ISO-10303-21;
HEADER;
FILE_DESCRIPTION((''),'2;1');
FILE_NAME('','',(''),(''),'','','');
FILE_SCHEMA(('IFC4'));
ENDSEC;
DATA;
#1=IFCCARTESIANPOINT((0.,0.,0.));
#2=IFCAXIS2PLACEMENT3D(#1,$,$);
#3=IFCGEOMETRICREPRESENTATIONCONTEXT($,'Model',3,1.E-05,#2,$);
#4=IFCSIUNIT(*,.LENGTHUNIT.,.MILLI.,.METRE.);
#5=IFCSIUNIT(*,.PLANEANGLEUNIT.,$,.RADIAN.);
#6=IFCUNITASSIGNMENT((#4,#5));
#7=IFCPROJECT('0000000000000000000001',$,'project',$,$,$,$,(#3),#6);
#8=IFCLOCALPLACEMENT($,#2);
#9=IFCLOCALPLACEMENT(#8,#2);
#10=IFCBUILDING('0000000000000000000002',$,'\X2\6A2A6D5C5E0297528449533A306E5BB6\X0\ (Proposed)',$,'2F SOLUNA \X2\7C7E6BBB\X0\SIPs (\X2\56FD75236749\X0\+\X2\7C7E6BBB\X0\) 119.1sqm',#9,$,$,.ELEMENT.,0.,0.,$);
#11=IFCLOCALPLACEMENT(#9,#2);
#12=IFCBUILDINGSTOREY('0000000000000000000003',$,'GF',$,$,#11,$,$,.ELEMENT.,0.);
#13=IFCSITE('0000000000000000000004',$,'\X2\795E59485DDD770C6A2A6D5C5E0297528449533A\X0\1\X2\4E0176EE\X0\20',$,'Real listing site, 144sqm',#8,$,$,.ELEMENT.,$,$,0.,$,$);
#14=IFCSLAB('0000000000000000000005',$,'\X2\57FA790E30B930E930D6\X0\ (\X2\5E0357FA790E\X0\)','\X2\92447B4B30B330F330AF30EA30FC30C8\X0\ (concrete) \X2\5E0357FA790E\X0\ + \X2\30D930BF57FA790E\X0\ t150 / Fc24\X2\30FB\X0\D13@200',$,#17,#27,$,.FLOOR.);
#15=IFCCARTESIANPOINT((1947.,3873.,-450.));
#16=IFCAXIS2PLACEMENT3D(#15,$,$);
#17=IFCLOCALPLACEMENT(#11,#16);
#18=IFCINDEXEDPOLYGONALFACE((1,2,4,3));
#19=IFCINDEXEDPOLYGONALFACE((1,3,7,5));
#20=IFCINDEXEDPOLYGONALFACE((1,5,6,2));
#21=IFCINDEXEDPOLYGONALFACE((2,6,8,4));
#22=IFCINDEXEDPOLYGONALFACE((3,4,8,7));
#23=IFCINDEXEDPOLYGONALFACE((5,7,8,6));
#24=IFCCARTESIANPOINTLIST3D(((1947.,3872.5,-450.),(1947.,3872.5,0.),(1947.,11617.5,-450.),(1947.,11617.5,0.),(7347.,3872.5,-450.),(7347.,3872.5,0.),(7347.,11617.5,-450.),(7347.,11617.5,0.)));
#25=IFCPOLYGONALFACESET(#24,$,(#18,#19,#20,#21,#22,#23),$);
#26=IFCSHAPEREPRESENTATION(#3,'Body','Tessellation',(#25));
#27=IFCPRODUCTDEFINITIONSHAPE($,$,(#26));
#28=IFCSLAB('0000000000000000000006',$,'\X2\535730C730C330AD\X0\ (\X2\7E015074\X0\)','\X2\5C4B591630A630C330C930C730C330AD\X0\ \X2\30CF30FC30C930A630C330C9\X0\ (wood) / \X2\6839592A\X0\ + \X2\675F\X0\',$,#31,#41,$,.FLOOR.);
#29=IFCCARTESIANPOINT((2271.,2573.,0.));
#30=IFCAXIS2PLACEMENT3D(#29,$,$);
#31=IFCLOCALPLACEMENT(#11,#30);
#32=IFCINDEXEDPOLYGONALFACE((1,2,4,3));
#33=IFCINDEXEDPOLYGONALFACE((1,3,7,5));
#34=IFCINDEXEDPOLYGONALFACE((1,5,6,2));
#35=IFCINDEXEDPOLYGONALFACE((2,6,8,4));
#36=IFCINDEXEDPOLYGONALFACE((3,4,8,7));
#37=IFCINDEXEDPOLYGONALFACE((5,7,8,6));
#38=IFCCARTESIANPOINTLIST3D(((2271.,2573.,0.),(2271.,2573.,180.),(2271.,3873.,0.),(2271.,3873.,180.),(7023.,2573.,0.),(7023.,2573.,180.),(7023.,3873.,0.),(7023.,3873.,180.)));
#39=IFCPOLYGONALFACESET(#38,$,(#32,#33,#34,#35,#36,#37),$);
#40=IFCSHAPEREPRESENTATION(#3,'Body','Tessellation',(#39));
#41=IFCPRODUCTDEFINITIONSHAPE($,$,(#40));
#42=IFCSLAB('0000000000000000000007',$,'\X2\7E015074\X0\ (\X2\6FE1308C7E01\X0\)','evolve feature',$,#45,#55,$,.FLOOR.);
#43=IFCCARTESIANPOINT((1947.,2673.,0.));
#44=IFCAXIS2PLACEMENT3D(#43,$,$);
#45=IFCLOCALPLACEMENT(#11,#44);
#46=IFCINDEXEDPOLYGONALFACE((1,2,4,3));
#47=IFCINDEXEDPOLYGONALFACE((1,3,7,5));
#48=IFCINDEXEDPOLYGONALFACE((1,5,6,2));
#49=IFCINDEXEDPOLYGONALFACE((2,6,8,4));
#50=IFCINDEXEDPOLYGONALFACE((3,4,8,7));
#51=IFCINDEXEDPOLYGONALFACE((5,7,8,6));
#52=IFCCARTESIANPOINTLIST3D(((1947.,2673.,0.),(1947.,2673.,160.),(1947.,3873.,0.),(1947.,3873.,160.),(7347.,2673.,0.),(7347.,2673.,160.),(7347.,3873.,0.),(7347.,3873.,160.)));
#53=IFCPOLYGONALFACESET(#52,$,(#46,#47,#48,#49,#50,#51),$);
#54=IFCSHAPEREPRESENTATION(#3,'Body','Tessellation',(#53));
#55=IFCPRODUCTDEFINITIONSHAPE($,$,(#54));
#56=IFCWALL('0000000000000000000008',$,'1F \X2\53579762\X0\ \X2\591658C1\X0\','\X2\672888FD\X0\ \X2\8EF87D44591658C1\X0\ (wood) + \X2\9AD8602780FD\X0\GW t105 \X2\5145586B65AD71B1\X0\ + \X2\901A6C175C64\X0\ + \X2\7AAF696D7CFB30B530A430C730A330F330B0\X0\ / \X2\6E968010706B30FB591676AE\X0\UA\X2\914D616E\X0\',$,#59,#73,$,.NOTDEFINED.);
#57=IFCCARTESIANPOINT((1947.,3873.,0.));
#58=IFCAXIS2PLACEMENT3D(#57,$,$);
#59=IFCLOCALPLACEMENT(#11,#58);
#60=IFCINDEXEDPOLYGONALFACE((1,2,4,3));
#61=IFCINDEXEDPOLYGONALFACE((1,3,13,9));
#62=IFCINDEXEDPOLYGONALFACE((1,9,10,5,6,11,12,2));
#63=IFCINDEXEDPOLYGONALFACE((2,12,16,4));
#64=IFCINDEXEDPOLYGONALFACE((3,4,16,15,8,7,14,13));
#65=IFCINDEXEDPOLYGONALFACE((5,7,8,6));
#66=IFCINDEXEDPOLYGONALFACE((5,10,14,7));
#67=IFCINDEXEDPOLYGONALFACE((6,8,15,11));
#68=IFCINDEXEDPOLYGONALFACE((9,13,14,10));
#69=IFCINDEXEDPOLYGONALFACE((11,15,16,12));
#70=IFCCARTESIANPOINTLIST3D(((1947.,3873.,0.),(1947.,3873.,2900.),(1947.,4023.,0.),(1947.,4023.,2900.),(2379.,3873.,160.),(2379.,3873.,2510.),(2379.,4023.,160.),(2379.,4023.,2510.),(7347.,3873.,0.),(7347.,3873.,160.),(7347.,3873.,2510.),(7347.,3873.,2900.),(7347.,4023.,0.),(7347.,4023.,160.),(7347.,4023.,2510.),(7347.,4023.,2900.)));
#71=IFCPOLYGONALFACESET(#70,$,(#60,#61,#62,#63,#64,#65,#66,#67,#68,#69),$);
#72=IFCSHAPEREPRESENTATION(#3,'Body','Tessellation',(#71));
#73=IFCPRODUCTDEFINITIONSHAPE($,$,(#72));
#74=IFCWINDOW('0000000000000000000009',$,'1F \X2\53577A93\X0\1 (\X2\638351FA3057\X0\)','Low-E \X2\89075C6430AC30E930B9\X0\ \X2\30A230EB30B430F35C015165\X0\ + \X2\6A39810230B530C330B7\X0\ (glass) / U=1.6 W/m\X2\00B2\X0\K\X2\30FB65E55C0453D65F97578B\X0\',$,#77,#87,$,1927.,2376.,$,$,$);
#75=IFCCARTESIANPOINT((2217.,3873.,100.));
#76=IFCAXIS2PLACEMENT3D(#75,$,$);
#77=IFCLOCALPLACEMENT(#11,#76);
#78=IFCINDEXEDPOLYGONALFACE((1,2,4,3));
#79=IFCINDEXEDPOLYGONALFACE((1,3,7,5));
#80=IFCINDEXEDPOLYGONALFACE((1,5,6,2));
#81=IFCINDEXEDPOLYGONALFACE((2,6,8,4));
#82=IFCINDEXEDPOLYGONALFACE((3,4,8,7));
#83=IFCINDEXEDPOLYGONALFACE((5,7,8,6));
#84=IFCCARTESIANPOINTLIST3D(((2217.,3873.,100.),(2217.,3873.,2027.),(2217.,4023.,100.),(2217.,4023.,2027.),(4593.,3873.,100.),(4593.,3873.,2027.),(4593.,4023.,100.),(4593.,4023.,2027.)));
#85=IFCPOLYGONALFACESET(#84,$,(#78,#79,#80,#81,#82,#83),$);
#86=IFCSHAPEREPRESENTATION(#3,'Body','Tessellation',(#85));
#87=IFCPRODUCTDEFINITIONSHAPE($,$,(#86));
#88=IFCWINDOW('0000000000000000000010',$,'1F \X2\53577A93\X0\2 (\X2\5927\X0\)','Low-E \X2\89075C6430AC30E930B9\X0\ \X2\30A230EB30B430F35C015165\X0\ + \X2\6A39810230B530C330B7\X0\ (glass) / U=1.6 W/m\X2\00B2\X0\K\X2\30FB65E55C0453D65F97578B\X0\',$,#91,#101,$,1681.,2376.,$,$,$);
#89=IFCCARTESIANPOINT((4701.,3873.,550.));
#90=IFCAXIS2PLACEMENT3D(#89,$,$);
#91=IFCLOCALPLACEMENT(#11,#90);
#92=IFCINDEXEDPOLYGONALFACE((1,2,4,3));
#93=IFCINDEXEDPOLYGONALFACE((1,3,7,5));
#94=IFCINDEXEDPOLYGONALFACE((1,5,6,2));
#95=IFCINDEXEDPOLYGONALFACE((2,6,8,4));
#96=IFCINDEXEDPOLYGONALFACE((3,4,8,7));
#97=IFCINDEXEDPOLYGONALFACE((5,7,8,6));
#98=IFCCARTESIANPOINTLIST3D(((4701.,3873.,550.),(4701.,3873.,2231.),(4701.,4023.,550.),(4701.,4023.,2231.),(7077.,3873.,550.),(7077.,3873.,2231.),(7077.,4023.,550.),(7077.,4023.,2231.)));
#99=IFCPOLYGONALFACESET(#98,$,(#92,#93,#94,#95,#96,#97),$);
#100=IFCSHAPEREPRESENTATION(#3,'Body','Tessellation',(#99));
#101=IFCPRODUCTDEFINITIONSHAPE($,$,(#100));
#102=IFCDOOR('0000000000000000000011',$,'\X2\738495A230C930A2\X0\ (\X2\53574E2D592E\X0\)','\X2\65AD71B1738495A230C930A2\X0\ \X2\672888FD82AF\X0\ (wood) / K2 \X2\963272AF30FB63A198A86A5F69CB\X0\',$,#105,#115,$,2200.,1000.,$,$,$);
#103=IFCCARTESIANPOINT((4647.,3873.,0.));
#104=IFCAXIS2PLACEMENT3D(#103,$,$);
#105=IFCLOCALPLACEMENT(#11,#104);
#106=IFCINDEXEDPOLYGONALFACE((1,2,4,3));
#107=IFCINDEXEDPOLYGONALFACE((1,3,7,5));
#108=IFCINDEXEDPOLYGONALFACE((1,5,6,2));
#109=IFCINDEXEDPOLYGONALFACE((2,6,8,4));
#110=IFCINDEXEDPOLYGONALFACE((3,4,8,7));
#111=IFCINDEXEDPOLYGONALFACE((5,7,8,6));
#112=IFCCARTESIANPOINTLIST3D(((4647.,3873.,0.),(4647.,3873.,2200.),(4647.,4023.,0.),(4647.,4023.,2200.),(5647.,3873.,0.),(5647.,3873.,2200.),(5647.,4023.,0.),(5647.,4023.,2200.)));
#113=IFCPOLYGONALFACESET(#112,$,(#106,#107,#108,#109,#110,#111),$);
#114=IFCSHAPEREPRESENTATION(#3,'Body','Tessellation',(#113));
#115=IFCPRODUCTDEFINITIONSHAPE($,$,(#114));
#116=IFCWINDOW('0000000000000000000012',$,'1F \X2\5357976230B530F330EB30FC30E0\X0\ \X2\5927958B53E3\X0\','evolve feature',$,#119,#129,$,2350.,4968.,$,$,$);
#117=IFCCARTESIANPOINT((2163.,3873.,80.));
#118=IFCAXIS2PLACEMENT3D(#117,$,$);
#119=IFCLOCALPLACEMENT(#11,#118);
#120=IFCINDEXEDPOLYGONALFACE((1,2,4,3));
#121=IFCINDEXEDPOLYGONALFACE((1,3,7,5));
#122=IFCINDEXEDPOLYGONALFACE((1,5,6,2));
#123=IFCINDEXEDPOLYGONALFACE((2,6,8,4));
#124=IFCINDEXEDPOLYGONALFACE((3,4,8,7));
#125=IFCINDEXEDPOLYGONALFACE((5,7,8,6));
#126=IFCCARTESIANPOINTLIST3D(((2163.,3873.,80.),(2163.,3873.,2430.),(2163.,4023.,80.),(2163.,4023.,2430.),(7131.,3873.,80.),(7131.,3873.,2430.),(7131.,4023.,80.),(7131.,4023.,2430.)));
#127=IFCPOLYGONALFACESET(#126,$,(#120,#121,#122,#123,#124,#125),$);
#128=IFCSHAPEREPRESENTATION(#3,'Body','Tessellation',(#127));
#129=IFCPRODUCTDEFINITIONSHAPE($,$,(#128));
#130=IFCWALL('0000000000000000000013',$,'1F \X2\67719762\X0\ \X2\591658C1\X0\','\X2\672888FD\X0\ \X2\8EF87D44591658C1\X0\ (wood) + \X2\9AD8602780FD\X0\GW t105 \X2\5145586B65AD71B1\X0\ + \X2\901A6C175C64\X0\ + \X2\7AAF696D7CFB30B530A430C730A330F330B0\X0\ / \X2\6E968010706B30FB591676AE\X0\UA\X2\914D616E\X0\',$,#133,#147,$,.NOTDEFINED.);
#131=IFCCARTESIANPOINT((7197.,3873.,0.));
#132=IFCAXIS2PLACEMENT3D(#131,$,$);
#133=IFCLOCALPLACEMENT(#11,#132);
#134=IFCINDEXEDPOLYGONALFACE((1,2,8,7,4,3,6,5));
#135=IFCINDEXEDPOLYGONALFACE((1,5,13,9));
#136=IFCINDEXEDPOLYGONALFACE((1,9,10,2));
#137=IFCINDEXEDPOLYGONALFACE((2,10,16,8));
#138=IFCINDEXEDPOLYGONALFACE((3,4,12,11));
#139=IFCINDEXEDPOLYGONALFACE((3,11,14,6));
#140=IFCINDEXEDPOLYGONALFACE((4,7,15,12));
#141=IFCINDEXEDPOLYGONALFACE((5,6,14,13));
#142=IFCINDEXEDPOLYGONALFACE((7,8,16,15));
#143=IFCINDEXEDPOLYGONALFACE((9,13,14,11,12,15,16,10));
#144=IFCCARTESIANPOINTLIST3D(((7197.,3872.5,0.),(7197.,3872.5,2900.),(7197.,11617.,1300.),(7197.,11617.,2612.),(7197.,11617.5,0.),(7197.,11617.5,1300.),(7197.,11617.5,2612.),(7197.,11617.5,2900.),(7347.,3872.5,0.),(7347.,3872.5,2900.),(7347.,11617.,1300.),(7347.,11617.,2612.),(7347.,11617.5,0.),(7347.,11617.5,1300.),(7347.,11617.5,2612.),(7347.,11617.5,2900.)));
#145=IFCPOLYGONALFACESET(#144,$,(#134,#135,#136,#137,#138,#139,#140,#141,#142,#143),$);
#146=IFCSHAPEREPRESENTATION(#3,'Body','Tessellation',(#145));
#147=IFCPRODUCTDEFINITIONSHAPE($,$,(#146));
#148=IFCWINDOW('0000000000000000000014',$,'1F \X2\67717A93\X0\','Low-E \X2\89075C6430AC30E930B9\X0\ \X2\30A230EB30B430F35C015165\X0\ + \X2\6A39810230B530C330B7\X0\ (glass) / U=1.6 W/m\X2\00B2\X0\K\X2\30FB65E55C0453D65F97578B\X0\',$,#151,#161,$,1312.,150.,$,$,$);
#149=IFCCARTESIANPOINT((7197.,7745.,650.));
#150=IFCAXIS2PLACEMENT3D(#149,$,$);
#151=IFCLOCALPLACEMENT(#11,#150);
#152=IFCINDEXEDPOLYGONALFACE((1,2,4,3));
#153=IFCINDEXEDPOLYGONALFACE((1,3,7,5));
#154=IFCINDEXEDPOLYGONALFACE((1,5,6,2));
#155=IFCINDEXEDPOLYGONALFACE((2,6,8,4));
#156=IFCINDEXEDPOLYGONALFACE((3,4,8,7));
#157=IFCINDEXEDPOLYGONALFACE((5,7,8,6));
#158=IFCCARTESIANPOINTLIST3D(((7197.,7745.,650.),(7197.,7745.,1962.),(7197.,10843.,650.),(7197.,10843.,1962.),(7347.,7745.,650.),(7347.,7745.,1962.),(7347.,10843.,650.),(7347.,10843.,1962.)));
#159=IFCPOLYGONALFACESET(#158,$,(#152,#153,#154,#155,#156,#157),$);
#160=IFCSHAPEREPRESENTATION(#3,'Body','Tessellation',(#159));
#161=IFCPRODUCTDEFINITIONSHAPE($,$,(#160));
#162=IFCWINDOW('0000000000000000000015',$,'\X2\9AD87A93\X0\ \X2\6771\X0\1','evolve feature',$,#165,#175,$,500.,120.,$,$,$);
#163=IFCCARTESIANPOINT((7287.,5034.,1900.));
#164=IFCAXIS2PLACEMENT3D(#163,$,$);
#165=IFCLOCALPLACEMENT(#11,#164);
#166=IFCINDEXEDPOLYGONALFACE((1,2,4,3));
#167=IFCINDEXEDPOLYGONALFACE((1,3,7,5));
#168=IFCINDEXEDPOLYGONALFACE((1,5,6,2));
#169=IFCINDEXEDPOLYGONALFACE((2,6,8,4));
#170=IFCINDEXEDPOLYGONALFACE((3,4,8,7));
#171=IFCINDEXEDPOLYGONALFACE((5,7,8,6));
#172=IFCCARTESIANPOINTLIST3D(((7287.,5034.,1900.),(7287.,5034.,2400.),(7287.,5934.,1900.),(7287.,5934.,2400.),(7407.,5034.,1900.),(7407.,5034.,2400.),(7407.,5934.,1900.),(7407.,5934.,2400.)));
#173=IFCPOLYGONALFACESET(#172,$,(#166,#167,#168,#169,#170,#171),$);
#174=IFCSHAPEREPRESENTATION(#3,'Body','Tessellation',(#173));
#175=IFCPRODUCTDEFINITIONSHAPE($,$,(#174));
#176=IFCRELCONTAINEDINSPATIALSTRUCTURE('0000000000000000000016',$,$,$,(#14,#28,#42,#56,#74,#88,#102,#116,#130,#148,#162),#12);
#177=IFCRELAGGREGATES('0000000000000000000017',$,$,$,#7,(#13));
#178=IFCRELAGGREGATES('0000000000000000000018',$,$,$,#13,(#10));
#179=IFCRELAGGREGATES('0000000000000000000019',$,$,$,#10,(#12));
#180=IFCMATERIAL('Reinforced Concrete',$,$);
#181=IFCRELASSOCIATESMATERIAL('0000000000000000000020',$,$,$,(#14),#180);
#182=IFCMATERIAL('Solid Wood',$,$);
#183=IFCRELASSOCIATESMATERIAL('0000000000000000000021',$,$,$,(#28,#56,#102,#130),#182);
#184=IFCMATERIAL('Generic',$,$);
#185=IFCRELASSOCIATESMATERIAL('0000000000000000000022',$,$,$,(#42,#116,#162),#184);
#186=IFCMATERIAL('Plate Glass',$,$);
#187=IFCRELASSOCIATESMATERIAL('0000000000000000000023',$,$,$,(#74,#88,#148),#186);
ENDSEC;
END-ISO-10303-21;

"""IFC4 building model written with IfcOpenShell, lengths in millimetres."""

from ifc_helpers import new_model, si_unit, frame, frame_2d, origin, place, context, project, spatial, rectangle, extrude, material, element, fill, save


model = new_model("IFC4")

# Units and contexts
model_context = context("Model", 3, precision=1e-05, world=origin())
ifc_project = project(units=[si_unit("LENGTHUNIT", "METRE", prefix="MILLI"), si_unit("PLANEANGLEUNIT", "RADIAN")], contexts=[model_context])

# Site, building, storey
site_placement = place(None, origin())
site = spatial("IfcSite", under=ifc_project, at=site_placement, Name="神奈川県横浜市青葉区1丁目20", ObjectType="Real listing site, 144sqm", CompositionType="ELEMENT", RefElevation=0.0)
building_placement = place(site_placement, origin())
building = spatial("IfcBuilding", under=site, at=building_placement, Name="横浜市青葉区の家 (Proposed)", ObjectType="2F SOLUNA 籾殻SIPs (国産杉+籾殻) 119.1sqm", CompositionType="ELEMENT", ElevationOfRefHeight=0.0, ElevationOfTerrain=0.0)
storey_placement = place(building_placement, origin())
storey = spatial("IfcBuildingStorey", under=building, at=storey_placement, Name="GF", CompositionType="ELEMENT", Elevation=0.0)

# Slabs
ifc_material_1 = material(Name="Reinforced Concrete")
slab_1_placement = place(storey_placement, frame((1947.0, 3873.0, -450.0)))
element("IfcSlab", 1, at=slab_1_placement, inside=storey, material=ifc_material_1, Name="基礎スラブ (布基礎)", Description="鉄筋コンクリート (concrete) 布基礎 + ベタ基礎 t150 / Fc24・D13@200", PredefinedType="FLOOR", context=model_context, shape_type="SweptSolid", body=[
    extrude(rectangle(XDim=5400.0, YDim=7745.0, at=frame_2d((2700.0, 3872.0))), frame((1947.0, 3873.0, -450.0)), (0.0, 0.0, 1.0), 450.0),
])
ifc_material_2 = material(Name="Solid Wood")
slab_2_placement = place(storey_placement, frame((2271.0, 2573.0, 0.0)))
element("IfcSlab", 2, at=slab_2_placement, inside=storey, material=ifc_material_2, Name="南デッキ (縁側)", Description="屋外ウッドデッキ ハードウッド (wood) / 根太 + 束", PredefinedType="FLOOR", context=model_context, shape_type="SweptSolid", body=[
    extrude(rectangle(XDim=4752.0, YDim=1300.0, at=frame_2d((2376.0, 650.0))), frame((2271.0, 2573.0, 0.0)), (0.0, 0.0, 1.0), 180.0),
])
ifc_material_3 = material(Name="Generic")
slab_3_placement = place(storey_placement, frame((1947.0, 2673.0, 0.0)))
element("IfcSlab", 3, at=slab_3_placement, inside=storey, material=ifc_material_3, Name="縁側 (濡れ縁)", Description="evolve feature", PredefinedType="FLOOR", context=model_context, shape_type="SweptSolid", body=[
    extrude(rectangle(XDim=5400.0, YDim=1200.0, at=frame_2d((2700.0, 600.0))), frame((1947.0, 2673.0, 0.0)), (0.0, 0.0, 1.0), 160.0),
])

# Wall, openings, windows, door
wall_1_placement = place(storey_placement, frame((1947.0, 3873.0, 0.0)))
wall_1 = element("IfcWall", 4, at=wall_1_placement, inside=storey, material=ifc_material_2, Name="1F 南面 外壁", Description="木製 軸組外壁 (wood) + 高性能GW t105 充填断熱 + 通気層 + 窯業系サイディング / 準耐火・外皮UA配慮", PredefinedType="NOTDEFINED", context=model_context, shape_type="SweptSolid", body=[
    extrude(rectangle(XDim=5400.0, YDim=150.0, at=frame_2d((2700.0, 75.0))), frame((1947.0, 3873.0, 0.0)), (0.0, 0.0, 1.0), 2900.0),
])
opening_1_placement = place(storey_placement, frame((2217.0, 3873.0, 100.0)))
opening_1 = element("IfcOpeningElement", 5, at=opening_1_placement, cuts=wall_1, PredefinedType="NOTDEFINED", context=model_context, shape_type="SweptSolid", body=[
    extrude(rectangle(XDim=2376.0, YDim=150.0, at=frame_2d((1188.0, 75.0))), frame((2217.0, 3873.0, 100.0)), (0.0, 0.0, 1.0), 1927.0),
])
opening_2_placement = place(storey_placement, frame((4701.0, 3873.0, 550.0)))
opening_2 = element("IfcOpeningElement", 6, at=opening_2_placement, cuts=wall_1, PredefinedType="NOTDEFINED", context=model_context, shape_type="SweptSolid", body=[
    extrude(rectangle(XDim=2376.0, YDim=150.0, at=frame_2d((1188.0, 75.0))), frame((4701.0, 3873.0, 550.0)), (0.0, 0.0, 1.0), 1681.0),
])
opening_3_placement = place(storey_placement, frame((4647.0, 3873.0, 0.0)))
opening_3 = element("IfcOpeningElement", 7, at=opening_3_placement, cuts=wall_1, PredefinedType="NOTDEFINED", context=model_context, shape_type="SweptSolid", body=[
    extrude(rectangle(XDim=1000.0, YDim=150.0, at=frame_2d((500.0, 75.0))), frame((4647.0, 3873.0, 0.0)), (0.0, 0.0, 1.0), 2200.0),
])
opening_4_placement = place(storey_placement, frame((2163.0, 3873.0, 80.0)))
opening_4 = element("IfcOpeningElement", 8, at=opening_4_placement, cuts=wall_1, PredefinedType="NOTDEFINED", context=model_context, shape_type="SweptSolid", body=[
    extrude(rectangle(XDim=4968.0, YDim=150.0, at=frame_2d((2484.0, 75.0))), frame((2163.0, 3873.0, 80.0)), (0.0, 0.0, 1.0), 2350.0),
])
ifc_material_4 = material(Name="Plate Glass")
window_1_placement = place(storey_placement, frame((2217.0, 3873.0, 100.0)))
window_1 = element("IfcWindow", 9, at=window_1_placement, inside=storey, material=ifc_material_4, Name="1F 南窓1 (掃出し)", Description="Low-E 複層ガラス アルゴン封入 + 樹脂サッシ (glass) / U=1.6 W/m²K・日射取得型", OverallHeight=1927.0, OverallWidth=2376.0, context=model_context, shape_type="SweptSolid", body=[
    extrude(rectangle(XDim=2376.0, YDim=150.0, at=frame_2d((1188.0, 75.0))), frame((2217.0, 3873.0, 100.0)), (0.0, 0.0, 1.0), 1927.0),
])
fill(opening_1, window_1)
window_2_placement = place(storey_placement, frame((4701.0, 3873.0, 550.0)))
window_2 = element("IfcWindow", 10, at=window_2_placement, inside=storey, material=ifc_material_4, Name="1F 南窓2 (大)", Description="Low-E 複層ガラス アルゴン封入 + 樹脂サッシ (glass) / U=1.6 W/m²K・日射取得型", OverallHeight=1681.0, OverallWidth=2376.0, context=model_context, shape_type="SweptSolid", body=[
    extrude(rectangle(XDim=2376.0, YDim=150.0, at=frame_2d((1188.0, 75.0))), frame((4701.0, 3873.0, 550.0)), (0.0, 0.0, 1.0), 1681.0),
])
fill(opening_2, window_2)
door_placement = place(storey_placement, frame((4647.0, 3873.0, 0.0)))
door = element("IfcDoor", 11, at=door_placement, inside=storey, material=ifc_material_2, Name="玄関ドア (南中央)", Description="断熱玄関ドア 木製芯 (wood) / K2 防犯・採風機構", OverallHeight=2200.0, OverallWidth=1000.0, context=model_context, shape_type="SweptSolid", body=[
    extrude(rectangle(XDim=1000.0, YDim=150.0, at=frame_2d((500.0, 75.0))), frame((4647.0, 3873.0, 0.0)), (0.0, 0.0, 1.0), 2200.0),
])
fill(opening_3, door)
window_3_placement = place(storey_placement, frame((2163.0, 3873.0, 80.0)))
window_3 = element("IfcWindow", 12, at=window_3_placement, inside=storey, material=ifc_material_3, Name="1F 南面サンルーム 大開口", Description="evolve feature", OverallHeight=2350.0, OverallWidth=4968.0, context=model_context, shape_type="SweptSolid", body=[
    extrude(rectangle(XDim=4968.0, YDim=150.0, at=frame_2d((2484.0, 75.0))), frame((2163.0, 3873.0, 80.0)), (0.0, 0.0, 1.0), 2350.0),
])
fill(opening_4, window_3)

# Wall, openings, windows
wall_2_placement = place(storey_placement, frame((7197.0, 3873.0, 0.0)))
wall_2 = element("IfcWall", 13, at=wall_2_placement, inside=storey, material=ifc_material_2, Name="1F 東面 外壁", Description="木製 軸組外壁 (wood) + 高性能GW t105 充填断熱 + 通気層 + 窯業系サイディング / 準耐火・外皮UA配慮", PredefinedType="NOTDEFINED", context=model_context, shape_type="SweptSolid", body=[
    extrude(rectangle(XDim=150.0, YDim=7745.0, at=frame_2d((75.0, 3872.0))), frame((7197.0, 3873.0, 0.0)), (0.0, 0.0, 1.0), 2900.0),
])
opening_5_placement = place(storey_placement, frame((7197.0, 7745.0, 650.0)))
opening_5 = element("IfcOpeningElement", 14, at=opening_5_placement, cuts=wall_2, PredefinedType="NOTDEFINED", context=model_context, shape_type="SweptSolid", body=[
    extrude(rectangle(XDim=150.0, YDim=3098.0, at=frame_2d((75.0, 1549.0))), frame((7197.0, 7745.0, 650.0)), (0.0, 0.0, 1.0), 1312.0),
])
opening_6_placement = place(storey_placement, frame((7287.0, 5034.0, 1900.0)))
opening_6 = element("IfcOpeningElement", 15, at=opening_6_placement, cuts=wall_2, PredefinedType="NOTDEFINED", context=model_context, shape_type="SweptSolid", body=[
    extrude(rectangle(XDim=120.0, YDim=900.0, at=frame_2d((60.0, 450.0))), frame((7287.0, 5034.0, 1900.0)), (0.0, 0.0, 1.0), 500.0),
])
window_4_placement = place(storey_placement, frame((7197.0, 7745.0, 650.0)))
window_4 = element("IfcWindow", 16, at=window_4_placement, inside=storey, material=ifc_material_4, Name="1F 東窓", Description="Low-E 複層ガラス アルゴン封入 + 樹脂サッシ (glass) / U=1.6 W/m²K・日射取得型", OverallHeight=1312.0, OverallWidth=150.0, context=model_context, shape_type="SweptSolid", body=[
    extrude(rectangle(XDim=150.0, YDim=3098.0, at=frame_2d((75.0, 1549.0))), frame((7197.0, 7745.0, 650.0)), (0.0, 0.0, 1.0), 1312.0),
])
fill(opening_5, window_4)
window_5_placement = place(storey_placement, frame((7287.0, 5034.0, 1900.0)))
window_5 = element("IfcWindow", 17, at=window_5_placement, inside=storey, material=ifc_material_3, Name="高窓 東1", Description="evolve feature", OverallHeight=500.0, OverallWidth=120.0, context=model_context, shape_type="SweptSolid", body=[
    extrude(rectangle(XDim=120.0, YDim=900.0, at=frame_2d((60.0, 450.0))), frame((7287.0, 5034.0, 1900.0)), (0.0, 0.0, 1.0), 500.0),
])
fill(opening_6, window_5)

save(model, "model.ifc")
